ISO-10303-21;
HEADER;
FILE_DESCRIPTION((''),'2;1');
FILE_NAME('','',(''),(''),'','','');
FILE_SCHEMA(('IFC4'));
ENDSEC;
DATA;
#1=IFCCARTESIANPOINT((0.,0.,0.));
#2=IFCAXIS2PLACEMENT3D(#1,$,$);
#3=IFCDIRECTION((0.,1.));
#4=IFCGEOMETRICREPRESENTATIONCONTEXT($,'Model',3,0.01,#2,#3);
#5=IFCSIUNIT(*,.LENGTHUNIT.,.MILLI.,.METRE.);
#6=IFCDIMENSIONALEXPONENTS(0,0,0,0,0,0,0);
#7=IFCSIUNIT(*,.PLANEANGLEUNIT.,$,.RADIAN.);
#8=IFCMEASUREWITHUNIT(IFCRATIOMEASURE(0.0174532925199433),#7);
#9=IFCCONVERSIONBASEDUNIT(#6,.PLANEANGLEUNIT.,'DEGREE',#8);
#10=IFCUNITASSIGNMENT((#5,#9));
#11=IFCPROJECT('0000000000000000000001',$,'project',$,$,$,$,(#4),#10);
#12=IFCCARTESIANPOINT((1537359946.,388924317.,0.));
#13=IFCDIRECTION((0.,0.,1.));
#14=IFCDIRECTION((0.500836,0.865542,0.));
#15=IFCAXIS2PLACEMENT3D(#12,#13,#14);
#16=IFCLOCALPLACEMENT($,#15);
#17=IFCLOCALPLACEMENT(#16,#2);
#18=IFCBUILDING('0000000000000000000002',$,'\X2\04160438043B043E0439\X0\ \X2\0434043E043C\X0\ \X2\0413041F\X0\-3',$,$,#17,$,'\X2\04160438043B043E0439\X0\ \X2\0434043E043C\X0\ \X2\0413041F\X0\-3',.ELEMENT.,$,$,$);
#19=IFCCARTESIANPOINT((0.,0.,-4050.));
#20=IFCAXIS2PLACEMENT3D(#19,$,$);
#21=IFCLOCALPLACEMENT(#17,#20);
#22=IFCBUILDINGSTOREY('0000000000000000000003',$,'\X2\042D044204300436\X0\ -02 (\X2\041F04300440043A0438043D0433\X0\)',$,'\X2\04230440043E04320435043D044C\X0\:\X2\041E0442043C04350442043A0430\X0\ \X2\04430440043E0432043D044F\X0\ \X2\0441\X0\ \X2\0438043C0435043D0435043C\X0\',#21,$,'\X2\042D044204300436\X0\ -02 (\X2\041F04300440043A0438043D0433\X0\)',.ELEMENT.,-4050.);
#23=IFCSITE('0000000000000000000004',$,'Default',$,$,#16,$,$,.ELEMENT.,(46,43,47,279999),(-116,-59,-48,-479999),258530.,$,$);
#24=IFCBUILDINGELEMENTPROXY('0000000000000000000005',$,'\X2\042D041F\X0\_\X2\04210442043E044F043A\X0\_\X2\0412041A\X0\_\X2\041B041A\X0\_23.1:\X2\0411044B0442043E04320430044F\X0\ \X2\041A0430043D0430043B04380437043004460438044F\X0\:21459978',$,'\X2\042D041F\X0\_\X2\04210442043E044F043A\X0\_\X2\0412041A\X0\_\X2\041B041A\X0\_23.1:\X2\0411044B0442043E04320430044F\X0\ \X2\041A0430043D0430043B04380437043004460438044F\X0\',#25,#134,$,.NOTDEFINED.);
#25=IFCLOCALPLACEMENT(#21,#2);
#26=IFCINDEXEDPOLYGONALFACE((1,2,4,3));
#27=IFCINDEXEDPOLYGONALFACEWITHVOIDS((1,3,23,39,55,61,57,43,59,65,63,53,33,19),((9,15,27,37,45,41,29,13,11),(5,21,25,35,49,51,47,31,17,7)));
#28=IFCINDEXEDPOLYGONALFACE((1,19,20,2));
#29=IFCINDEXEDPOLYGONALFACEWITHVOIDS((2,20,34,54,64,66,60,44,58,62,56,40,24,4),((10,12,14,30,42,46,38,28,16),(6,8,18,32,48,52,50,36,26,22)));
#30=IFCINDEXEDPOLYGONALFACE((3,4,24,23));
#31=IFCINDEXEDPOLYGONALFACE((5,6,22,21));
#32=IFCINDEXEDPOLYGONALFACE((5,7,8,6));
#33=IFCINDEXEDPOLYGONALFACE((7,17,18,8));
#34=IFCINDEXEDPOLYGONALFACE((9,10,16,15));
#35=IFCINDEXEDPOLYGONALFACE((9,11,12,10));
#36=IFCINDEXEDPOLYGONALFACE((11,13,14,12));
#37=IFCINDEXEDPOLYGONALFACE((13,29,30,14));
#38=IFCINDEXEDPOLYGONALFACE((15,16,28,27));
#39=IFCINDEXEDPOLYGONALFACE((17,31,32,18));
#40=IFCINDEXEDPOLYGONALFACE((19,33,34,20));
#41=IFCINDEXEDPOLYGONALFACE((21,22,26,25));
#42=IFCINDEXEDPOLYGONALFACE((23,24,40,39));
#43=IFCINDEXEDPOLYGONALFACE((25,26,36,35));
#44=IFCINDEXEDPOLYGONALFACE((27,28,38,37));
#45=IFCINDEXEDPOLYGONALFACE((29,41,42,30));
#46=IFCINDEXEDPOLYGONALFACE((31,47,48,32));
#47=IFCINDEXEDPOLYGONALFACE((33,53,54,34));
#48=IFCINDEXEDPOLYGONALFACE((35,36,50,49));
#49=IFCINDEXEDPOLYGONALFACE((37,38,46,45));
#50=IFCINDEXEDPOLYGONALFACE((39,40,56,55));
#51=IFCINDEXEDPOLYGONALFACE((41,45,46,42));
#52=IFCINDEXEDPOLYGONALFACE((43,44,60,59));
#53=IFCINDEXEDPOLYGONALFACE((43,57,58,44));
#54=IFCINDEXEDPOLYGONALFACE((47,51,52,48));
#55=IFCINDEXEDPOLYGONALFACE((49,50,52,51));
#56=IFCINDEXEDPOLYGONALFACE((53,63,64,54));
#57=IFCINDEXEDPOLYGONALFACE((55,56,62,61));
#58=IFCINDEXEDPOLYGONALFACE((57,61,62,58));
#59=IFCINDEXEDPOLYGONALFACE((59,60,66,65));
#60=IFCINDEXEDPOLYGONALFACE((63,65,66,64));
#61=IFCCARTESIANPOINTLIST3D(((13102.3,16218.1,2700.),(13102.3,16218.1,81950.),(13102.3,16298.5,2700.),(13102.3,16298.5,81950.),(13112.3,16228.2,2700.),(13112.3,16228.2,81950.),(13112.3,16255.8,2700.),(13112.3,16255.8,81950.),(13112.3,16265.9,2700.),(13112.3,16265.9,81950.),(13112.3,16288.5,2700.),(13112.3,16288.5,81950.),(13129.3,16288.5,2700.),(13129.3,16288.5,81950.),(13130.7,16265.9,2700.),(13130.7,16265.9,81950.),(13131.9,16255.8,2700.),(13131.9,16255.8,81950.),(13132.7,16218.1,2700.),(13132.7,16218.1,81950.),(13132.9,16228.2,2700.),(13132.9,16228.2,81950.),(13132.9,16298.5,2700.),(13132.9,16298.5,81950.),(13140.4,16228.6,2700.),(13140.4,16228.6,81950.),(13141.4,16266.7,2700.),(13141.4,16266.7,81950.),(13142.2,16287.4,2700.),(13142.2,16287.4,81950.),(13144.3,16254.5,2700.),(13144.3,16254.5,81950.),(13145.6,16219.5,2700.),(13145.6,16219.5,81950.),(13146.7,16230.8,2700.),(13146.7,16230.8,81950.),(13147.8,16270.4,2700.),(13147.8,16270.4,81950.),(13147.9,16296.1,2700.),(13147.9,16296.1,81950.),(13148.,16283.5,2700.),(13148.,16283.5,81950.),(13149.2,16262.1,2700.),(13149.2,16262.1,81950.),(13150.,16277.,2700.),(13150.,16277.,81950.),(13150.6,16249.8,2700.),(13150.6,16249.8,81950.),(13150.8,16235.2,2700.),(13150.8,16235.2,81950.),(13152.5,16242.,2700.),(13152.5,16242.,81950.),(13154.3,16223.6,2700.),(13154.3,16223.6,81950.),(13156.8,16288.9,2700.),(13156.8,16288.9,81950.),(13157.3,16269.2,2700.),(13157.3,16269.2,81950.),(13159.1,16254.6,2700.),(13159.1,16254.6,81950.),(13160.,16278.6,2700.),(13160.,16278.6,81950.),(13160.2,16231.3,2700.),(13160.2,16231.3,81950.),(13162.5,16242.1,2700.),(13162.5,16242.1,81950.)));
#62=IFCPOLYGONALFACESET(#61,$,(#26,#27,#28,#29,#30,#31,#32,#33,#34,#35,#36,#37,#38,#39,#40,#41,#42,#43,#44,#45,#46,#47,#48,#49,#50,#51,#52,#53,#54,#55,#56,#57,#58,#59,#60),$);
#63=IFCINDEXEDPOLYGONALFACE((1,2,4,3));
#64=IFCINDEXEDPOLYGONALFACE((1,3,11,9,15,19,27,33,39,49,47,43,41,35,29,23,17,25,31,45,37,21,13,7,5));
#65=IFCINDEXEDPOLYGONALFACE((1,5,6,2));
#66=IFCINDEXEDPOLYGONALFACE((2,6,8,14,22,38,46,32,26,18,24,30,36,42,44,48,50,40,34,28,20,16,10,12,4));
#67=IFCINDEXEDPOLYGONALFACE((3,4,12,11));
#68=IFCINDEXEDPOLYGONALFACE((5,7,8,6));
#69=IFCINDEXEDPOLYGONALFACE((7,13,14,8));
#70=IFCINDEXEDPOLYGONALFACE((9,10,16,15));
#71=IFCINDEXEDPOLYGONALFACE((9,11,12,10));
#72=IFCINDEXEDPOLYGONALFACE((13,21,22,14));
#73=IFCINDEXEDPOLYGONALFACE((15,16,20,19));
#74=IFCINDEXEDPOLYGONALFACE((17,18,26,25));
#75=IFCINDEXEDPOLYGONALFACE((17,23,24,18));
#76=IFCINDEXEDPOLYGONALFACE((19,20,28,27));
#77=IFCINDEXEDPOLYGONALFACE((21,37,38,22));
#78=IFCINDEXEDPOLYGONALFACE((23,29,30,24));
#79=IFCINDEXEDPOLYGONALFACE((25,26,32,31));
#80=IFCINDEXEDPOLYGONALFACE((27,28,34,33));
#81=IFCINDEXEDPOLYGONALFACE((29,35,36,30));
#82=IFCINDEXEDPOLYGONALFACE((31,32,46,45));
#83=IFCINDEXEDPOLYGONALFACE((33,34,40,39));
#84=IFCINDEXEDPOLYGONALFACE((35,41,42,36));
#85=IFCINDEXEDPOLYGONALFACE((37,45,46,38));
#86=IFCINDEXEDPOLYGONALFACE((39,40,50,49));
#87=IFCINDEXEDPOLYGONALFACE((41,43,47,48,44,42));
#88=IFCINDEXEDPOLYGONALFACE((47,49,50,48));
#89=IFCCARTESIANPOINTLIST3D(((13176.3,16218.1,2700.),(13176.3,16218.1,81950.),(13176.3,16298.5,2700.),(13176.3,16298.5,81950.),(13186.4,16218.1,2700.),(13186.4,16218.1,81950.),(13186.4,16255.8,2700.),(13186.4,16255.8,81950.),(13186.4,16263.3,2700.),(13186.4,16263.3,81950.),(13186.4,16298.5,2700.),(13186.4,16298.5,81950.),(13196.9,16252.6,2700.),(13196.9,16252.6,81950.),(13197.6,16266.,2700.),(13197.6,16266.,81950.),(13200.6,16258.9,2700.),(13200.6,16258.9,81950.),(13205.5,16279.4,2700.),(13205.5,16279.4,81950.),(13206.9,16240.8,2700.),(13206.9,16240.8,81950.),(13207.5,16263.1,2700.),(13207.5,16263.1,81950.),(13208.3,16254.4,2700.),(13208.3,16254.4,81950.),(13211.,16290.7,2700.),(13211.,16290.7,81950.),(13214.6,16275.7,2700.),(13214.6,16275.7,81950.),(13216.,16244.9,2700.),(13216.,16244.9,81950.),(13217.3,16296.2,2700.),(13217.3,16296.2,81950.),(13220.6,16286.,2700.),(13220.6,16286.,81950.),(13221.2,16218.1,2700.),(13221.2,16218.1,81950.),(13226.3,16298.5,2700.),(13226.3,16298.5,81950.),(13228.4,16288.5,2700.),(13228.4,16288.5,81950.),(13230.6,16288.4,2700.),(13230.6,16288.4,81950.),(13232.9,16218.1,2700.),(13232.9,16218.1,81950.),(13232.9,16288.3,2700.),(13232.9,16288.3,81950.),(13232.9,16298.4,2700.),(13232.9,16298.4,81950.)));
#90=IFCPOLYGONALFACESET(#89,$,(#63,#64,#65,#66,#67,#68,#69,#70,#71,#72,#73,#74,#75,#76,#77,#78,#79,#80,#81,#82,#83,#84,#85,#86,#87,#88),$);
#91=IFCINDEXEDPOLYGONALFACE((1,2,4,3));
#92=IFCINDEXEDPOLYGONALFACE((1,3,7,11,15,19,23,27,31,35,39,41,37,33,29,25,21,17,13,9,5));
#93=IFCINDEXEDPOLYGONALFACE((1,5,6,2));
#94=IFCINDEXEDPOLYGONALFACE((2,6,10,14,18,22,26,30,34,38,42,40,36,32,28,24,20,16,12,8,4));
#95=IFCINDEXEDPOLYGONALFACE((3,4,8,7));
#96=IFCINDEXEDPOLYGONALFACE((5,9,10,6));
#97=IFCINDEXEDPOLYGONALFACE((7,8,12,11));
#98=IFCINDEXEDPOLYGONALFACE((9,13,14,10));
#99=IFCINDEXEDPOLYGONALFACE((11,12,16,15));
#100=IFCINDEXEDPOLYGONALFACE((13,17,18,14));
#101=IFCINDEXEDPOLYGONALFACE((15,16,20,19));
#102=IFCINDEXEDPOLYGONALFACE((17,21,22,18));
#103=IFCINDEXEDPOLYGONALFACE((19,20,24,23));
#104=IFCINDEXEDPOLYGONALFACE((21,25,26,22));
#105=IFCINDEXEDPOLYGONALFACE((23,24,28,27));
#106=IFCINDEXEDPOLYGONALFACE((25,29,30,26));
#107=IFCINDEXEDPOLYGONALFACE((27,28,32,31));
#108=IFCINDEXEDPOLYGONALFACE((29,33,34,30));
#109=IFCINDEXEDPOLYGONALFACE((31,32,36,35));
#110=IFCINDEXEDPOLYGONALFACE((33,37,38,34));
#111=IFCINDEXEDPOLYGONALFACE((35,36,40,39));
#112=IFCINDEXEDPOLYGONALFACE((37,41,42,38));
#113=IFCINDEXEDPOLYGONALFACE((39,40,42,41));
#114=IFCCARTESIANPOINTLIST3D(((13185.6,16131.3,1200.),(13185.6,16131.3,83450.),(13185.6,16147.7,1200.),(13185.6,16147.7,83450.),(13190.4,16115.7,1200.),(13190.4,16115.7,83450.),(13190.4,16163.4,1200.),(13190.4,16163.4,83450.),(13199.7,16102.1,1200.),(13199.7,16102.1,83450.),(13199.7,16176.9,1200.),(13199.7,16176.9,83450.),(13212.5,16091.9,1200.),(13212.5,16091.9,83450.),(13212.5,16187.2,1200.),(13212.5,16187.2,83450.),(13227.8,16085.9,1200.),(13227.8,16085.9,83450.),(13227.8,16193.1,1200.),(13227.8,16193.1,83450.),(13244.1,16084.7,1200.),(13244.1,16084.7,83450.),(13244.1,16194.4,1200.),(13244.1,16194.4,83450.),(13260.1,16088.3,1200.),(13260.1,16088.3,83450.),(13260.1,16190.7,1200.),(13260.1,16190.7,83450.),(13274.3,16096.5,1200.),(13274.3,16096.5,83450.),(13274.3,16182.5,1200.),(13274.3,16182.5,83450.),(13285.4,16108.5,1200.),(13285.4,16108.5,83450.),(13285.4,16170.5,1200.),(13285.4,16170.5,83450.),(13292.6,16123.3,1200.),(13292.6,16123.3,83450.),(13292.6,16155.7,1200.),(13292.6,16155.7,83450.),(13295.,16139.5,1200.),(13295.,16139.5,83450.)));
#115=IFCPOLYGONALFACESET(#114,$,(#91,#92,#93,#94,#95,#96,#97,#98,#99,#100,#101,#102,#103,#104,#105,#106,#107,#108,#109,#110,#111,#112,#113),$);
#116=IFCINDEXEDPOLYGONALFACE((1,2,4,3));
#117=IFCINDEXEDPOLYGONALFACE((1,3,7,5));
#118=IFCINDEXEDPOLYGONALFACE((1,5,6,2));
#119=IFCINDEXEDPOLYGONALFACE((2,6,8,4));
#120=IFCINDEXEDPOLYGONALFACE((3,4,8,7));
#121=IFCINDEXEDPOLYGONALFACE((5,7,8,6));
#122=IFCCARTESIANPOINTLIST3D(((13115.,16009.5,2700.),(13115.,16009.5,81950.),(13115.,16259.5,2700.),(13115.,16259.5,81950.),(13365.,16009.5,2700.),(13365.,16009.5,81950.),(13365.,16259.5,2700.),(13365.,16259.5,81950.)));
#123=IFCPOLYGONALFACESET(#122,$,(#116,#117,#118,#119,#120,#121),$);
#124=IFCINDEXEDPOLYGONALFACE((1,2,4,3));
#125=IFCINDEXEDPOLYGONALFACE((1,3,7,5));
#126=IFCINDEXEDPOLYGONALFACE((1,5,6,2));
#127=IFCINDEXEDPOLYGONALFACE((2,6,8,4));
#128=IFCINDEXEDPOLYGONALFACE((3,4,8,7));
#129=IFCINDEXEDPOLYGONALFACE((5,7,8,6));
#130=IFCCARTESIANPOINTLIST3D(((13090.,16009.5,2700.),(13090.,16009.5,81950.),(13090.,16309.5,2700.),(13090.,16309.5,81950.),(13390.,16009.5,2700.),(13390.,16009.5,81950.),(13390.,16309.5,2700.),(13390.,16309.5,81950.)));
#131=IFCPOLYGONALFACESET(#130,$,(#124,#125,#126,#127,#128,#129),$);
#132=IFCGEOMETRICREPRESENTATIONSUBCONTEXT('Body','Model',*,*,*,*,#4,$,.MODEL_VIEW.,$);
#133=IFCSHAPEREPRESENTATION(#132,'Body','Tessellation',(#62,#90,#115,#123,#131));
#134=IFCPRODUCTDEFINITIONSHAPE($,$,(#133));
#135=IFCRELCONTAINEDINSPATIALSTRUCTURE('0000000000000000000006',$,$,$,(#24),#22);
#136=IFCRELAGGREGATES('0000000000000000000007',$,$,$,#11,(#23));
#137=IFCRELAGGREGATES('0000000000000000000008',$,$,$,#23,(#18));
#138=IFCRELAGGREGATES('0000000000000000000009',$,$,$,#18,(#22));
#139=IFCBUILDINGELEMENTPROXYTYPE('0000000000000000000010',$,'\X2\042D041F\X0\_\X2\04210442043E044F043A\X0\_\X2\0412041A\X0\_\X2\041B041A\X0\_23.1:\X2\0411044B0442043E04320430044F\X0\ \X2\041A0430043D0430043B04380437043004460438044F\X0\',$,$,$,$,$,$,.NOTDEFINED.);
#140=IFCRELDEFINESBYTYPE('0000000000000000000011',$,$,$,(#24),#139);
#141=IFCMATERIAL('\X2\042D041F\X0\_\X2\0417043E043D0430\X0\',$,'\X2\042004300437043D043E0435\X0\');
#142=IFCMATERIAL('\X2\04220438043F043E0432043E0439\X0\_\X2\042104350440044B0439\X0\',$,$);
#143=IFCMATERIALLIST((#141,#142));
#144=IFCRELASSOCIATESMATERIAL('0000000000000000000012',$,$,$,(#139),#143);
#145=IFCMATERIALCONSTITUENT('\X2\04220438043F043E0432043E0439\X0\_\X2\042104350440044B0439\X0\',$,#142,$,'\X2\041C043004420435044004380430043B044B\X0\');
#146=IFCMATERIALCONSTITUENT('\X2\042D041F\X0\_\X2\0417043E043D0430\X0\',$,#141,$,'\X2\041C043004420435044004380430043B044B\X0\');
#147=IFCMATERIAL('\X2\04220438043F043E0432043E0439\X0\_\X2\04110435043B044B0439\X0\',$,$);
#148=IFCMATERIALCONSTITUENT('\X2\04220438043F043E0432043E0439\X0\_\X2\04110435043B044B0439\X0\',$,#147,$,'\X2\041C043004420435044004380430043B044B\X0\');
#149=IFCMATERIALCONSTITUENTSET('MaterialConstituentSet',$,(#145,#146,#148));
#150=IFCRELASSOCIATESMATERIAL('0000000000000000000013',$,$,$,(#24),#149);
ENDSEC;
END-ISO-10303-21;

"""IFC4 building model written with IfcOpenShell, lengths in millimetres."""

from ifc_helpers import new_model, entity, si_unit, converted_unit, direction, frame, frame_2d, origin, place, context, subcontext, project, spatial, polyline, rectangle, circle, outline, extrude, source, transform, mapped, material, material_list, constituent, constituent_set, type_object, type_shapes, element, save


model = new_model("IFC4")

# Units and contexts
model_context = context("Model", 3, precision=0.01, world=origin(), true_north=direction((0.0, 1.0)))
body_context = subcontext(model_context, "Body", "Model", "MODEL_VIEW")
ifc_project = project(units=[si_unit("LENGTHUNIT", "METRE", prefix="MILLI"), converted_unit("PLANEANGLEUNIT", "DEGREE", entity("IfcRatioMeasure", 0.0174532925199433), si_unit("PLANEANGLEUNIT", "RADIAN"), dimensions=[0, 0, 0, 0, 0, 0, 0])], contexts=[model_context])

# Site, building, storey
site_placement = place(None, frame((1537359946.0, 388924317.0, 0.0), z_axis=(0.0, 0.0, 1.0), x_axis=(0.500836, 0.865542, 0.0)))
site = spatial("IfcSite", under=ifc_project, at=site_placement, Name="Default", CompositionType="ELEMENT", RefLatitude=(46, 43, 47, 279999), RefLongitude=(-116, -59, -48, -479999), RefElevation=258530.0)
building_placement = place(site_placement, origin())
building = spatial("IfcBuilding", under=site, at=building_placement, Name="Жилой дом ГП-3", LongName="Жилой дом ГП-3", CompositionType="ELEMENT")
storey_placement = place(building_placement, frame((0.0, 0.0, -4050.0)))
storey = spatial("IfcBuildingStorey", under=building, at=storey_placement, Name="Этаж -02 (Паркинг)", ObjectType="Уровень:Отметка уровня с именем", LongName="Этаж -02 (Паркинг)", CompositionType="ELEMENT", Elevation=-4050.0)

# Building element proxy
ifc_material_1 = material(Name="ЭП_Зона", Category="Разное")
ifc_material_2 = material(Name="Типовой_Белый")
ifc_material_3 = material(Name="Типовой_Серый")
ifc_material_list_1 = material_list([ifc_material_1, ifc_material_3])
building_element_proxy_type_1 = type_object("IfcBuildingElementProxyType", Name="ЭП_Стояк_ВК_ЛК_23.1:Бытовая Канализация", PredefinedType="NOTDEFINED", material=ifc_material_list_1)
shared_shape_1 = source(origin(), body_context, "Body", "SweptSolid", [
    extrude(outline(polyline([(-42.2, -39.0), (-11.8, -39.0), (1.1, -37.6), (9.8, -33.5), (15.7, -25.8), (18.0, -15.0), (14.6, -2.5), (4.7, 5.0), (12.8, 12.1), (15.5, 21.5), (12.3, 31.8), (3.4, 39.0), (-11.6, 41.4), (-42.2, 41.4), (-42.2, -39.0)]), holes=[polyline([(-32.2, 8.8), (-32.2, 31.4), (-15.2, 31.4), (-2.3, 30.3), (3.5, 26.4), (5.5, 19.9), (3.3, 13.3), (-3.1, 9.6), (-13.9, 8.8), (-32.2, 8.8)]), polyline([(-32.2, -28.9), (-32.2, -1.3), (-12.6, -1.3), (-0.2, -2.6), (6.1, -7.3), (8.0, -15.1), (6.3, -21.9), (2.2, -26.3), (-4.1, -28.5), (-11.6, -28.9), (-32.2, -28.9)])]), frame((54.5, -52.4, -1350.0)), (0.0, 0.0, 1.0), 79250.0),
    extrude(outline(polyline([(-32.1, -31.9), (48.3, -31.9), (48.3, -21.8), (10.6, -21.8), (13.8, -11.4), (25.6, -1.3), (48.3, 13.0), (48.3, 24.6), (21.4, 7.7), (12.0, 0.1), (7.4, -7.7), (3.3, -0.7), (-9.3, 6.4), (-19.7, 12.3), (-22.1, 20.2), (-22.0, 22.4), (-22.0, 24.6), (-32.0, 24.6), (-32.1, 18.0), (-29.9, 9.0), (-24.3, 2.8), (-13.1, -2.8), (0.4, -10.6), (3.0, -21.8), (-32.1, -21.8), (-32.1, -31.9)])), frame((118.2, -43.1, -1350.0), z_axis=(0.0, 0.0, 1.0), x_axis=(0.0, -1.0, 0.0)), (0.0, 0.0, 1.0), 79250.0),
    extrude(circle(Radius=55.0, at=frame_2d((0.0, 0.0), x_axis=(1.0, 0.0))), frame((150.0, -170.0, -2850.0)), (0.0, 0.0, 1.0), 82250.0),
    extrude(rectangle(XDim=250.0, YDim=250.0, at=frame_2d((0.0, 0.0), x_axis=(1.0, 0.0))), frame((150.0, -175.0, -1350.0)), (0.0, 0.0, 1.0), 79250.0),
    extrude(rectangle(XDim=300.0, YDim=300.0, at=frame_2d((0.0, 0.0), x_axis=(1.0, 0.0))), frame((150.0, -150.0, -1350.0)), (0.0, 0.0, 1.0), 79250.0),
])
type_shapes(building_element_proxy_type_1, [shared_shape_1])
ifc_constituent_1 = constituent(ifc_material_3, Name="Типовой_Серый", Category="Материалы")
ifc_constituent_2 = constituent(ifc_material_1, Name="ЭП_Зона", Category="Материалы")
ifc_constituent_3 = constituent(ifc_material_2, Name="Типовой_Белый", Category="Материалы")
ifc_constituent_set_1 = constituent_set(constituents=[ifc_constituent_1, ifc_constituent_2, ifc_constituent_3], Name="MaterialConstituentSet")
proxy_1_placement = place(storey_placement, frame((13090.0, 16309.5, 4050.0)))
element("IfcBuildingElementProxy", 1, at=proxy_1_placement, inside=storey, type_object=building_element_proxy_type_1, material=ifc_constituent_set_1, Name="ЭП_Стояк_ВК_ЛК_23.1:Бытовая Канализация:21459978", ObjectType="ЭП_Стояк_ВК_ЛК_23.1:Бытовая Канализация", PredefinedType="NOTDEFINED", context=body_context, shape_type="MappedRepresentation", body=[
    mapped(shared_shape_1, transform((0.0, 0.0, 0.0), scale=1.0)),
])

save(model, "model.ifc")
